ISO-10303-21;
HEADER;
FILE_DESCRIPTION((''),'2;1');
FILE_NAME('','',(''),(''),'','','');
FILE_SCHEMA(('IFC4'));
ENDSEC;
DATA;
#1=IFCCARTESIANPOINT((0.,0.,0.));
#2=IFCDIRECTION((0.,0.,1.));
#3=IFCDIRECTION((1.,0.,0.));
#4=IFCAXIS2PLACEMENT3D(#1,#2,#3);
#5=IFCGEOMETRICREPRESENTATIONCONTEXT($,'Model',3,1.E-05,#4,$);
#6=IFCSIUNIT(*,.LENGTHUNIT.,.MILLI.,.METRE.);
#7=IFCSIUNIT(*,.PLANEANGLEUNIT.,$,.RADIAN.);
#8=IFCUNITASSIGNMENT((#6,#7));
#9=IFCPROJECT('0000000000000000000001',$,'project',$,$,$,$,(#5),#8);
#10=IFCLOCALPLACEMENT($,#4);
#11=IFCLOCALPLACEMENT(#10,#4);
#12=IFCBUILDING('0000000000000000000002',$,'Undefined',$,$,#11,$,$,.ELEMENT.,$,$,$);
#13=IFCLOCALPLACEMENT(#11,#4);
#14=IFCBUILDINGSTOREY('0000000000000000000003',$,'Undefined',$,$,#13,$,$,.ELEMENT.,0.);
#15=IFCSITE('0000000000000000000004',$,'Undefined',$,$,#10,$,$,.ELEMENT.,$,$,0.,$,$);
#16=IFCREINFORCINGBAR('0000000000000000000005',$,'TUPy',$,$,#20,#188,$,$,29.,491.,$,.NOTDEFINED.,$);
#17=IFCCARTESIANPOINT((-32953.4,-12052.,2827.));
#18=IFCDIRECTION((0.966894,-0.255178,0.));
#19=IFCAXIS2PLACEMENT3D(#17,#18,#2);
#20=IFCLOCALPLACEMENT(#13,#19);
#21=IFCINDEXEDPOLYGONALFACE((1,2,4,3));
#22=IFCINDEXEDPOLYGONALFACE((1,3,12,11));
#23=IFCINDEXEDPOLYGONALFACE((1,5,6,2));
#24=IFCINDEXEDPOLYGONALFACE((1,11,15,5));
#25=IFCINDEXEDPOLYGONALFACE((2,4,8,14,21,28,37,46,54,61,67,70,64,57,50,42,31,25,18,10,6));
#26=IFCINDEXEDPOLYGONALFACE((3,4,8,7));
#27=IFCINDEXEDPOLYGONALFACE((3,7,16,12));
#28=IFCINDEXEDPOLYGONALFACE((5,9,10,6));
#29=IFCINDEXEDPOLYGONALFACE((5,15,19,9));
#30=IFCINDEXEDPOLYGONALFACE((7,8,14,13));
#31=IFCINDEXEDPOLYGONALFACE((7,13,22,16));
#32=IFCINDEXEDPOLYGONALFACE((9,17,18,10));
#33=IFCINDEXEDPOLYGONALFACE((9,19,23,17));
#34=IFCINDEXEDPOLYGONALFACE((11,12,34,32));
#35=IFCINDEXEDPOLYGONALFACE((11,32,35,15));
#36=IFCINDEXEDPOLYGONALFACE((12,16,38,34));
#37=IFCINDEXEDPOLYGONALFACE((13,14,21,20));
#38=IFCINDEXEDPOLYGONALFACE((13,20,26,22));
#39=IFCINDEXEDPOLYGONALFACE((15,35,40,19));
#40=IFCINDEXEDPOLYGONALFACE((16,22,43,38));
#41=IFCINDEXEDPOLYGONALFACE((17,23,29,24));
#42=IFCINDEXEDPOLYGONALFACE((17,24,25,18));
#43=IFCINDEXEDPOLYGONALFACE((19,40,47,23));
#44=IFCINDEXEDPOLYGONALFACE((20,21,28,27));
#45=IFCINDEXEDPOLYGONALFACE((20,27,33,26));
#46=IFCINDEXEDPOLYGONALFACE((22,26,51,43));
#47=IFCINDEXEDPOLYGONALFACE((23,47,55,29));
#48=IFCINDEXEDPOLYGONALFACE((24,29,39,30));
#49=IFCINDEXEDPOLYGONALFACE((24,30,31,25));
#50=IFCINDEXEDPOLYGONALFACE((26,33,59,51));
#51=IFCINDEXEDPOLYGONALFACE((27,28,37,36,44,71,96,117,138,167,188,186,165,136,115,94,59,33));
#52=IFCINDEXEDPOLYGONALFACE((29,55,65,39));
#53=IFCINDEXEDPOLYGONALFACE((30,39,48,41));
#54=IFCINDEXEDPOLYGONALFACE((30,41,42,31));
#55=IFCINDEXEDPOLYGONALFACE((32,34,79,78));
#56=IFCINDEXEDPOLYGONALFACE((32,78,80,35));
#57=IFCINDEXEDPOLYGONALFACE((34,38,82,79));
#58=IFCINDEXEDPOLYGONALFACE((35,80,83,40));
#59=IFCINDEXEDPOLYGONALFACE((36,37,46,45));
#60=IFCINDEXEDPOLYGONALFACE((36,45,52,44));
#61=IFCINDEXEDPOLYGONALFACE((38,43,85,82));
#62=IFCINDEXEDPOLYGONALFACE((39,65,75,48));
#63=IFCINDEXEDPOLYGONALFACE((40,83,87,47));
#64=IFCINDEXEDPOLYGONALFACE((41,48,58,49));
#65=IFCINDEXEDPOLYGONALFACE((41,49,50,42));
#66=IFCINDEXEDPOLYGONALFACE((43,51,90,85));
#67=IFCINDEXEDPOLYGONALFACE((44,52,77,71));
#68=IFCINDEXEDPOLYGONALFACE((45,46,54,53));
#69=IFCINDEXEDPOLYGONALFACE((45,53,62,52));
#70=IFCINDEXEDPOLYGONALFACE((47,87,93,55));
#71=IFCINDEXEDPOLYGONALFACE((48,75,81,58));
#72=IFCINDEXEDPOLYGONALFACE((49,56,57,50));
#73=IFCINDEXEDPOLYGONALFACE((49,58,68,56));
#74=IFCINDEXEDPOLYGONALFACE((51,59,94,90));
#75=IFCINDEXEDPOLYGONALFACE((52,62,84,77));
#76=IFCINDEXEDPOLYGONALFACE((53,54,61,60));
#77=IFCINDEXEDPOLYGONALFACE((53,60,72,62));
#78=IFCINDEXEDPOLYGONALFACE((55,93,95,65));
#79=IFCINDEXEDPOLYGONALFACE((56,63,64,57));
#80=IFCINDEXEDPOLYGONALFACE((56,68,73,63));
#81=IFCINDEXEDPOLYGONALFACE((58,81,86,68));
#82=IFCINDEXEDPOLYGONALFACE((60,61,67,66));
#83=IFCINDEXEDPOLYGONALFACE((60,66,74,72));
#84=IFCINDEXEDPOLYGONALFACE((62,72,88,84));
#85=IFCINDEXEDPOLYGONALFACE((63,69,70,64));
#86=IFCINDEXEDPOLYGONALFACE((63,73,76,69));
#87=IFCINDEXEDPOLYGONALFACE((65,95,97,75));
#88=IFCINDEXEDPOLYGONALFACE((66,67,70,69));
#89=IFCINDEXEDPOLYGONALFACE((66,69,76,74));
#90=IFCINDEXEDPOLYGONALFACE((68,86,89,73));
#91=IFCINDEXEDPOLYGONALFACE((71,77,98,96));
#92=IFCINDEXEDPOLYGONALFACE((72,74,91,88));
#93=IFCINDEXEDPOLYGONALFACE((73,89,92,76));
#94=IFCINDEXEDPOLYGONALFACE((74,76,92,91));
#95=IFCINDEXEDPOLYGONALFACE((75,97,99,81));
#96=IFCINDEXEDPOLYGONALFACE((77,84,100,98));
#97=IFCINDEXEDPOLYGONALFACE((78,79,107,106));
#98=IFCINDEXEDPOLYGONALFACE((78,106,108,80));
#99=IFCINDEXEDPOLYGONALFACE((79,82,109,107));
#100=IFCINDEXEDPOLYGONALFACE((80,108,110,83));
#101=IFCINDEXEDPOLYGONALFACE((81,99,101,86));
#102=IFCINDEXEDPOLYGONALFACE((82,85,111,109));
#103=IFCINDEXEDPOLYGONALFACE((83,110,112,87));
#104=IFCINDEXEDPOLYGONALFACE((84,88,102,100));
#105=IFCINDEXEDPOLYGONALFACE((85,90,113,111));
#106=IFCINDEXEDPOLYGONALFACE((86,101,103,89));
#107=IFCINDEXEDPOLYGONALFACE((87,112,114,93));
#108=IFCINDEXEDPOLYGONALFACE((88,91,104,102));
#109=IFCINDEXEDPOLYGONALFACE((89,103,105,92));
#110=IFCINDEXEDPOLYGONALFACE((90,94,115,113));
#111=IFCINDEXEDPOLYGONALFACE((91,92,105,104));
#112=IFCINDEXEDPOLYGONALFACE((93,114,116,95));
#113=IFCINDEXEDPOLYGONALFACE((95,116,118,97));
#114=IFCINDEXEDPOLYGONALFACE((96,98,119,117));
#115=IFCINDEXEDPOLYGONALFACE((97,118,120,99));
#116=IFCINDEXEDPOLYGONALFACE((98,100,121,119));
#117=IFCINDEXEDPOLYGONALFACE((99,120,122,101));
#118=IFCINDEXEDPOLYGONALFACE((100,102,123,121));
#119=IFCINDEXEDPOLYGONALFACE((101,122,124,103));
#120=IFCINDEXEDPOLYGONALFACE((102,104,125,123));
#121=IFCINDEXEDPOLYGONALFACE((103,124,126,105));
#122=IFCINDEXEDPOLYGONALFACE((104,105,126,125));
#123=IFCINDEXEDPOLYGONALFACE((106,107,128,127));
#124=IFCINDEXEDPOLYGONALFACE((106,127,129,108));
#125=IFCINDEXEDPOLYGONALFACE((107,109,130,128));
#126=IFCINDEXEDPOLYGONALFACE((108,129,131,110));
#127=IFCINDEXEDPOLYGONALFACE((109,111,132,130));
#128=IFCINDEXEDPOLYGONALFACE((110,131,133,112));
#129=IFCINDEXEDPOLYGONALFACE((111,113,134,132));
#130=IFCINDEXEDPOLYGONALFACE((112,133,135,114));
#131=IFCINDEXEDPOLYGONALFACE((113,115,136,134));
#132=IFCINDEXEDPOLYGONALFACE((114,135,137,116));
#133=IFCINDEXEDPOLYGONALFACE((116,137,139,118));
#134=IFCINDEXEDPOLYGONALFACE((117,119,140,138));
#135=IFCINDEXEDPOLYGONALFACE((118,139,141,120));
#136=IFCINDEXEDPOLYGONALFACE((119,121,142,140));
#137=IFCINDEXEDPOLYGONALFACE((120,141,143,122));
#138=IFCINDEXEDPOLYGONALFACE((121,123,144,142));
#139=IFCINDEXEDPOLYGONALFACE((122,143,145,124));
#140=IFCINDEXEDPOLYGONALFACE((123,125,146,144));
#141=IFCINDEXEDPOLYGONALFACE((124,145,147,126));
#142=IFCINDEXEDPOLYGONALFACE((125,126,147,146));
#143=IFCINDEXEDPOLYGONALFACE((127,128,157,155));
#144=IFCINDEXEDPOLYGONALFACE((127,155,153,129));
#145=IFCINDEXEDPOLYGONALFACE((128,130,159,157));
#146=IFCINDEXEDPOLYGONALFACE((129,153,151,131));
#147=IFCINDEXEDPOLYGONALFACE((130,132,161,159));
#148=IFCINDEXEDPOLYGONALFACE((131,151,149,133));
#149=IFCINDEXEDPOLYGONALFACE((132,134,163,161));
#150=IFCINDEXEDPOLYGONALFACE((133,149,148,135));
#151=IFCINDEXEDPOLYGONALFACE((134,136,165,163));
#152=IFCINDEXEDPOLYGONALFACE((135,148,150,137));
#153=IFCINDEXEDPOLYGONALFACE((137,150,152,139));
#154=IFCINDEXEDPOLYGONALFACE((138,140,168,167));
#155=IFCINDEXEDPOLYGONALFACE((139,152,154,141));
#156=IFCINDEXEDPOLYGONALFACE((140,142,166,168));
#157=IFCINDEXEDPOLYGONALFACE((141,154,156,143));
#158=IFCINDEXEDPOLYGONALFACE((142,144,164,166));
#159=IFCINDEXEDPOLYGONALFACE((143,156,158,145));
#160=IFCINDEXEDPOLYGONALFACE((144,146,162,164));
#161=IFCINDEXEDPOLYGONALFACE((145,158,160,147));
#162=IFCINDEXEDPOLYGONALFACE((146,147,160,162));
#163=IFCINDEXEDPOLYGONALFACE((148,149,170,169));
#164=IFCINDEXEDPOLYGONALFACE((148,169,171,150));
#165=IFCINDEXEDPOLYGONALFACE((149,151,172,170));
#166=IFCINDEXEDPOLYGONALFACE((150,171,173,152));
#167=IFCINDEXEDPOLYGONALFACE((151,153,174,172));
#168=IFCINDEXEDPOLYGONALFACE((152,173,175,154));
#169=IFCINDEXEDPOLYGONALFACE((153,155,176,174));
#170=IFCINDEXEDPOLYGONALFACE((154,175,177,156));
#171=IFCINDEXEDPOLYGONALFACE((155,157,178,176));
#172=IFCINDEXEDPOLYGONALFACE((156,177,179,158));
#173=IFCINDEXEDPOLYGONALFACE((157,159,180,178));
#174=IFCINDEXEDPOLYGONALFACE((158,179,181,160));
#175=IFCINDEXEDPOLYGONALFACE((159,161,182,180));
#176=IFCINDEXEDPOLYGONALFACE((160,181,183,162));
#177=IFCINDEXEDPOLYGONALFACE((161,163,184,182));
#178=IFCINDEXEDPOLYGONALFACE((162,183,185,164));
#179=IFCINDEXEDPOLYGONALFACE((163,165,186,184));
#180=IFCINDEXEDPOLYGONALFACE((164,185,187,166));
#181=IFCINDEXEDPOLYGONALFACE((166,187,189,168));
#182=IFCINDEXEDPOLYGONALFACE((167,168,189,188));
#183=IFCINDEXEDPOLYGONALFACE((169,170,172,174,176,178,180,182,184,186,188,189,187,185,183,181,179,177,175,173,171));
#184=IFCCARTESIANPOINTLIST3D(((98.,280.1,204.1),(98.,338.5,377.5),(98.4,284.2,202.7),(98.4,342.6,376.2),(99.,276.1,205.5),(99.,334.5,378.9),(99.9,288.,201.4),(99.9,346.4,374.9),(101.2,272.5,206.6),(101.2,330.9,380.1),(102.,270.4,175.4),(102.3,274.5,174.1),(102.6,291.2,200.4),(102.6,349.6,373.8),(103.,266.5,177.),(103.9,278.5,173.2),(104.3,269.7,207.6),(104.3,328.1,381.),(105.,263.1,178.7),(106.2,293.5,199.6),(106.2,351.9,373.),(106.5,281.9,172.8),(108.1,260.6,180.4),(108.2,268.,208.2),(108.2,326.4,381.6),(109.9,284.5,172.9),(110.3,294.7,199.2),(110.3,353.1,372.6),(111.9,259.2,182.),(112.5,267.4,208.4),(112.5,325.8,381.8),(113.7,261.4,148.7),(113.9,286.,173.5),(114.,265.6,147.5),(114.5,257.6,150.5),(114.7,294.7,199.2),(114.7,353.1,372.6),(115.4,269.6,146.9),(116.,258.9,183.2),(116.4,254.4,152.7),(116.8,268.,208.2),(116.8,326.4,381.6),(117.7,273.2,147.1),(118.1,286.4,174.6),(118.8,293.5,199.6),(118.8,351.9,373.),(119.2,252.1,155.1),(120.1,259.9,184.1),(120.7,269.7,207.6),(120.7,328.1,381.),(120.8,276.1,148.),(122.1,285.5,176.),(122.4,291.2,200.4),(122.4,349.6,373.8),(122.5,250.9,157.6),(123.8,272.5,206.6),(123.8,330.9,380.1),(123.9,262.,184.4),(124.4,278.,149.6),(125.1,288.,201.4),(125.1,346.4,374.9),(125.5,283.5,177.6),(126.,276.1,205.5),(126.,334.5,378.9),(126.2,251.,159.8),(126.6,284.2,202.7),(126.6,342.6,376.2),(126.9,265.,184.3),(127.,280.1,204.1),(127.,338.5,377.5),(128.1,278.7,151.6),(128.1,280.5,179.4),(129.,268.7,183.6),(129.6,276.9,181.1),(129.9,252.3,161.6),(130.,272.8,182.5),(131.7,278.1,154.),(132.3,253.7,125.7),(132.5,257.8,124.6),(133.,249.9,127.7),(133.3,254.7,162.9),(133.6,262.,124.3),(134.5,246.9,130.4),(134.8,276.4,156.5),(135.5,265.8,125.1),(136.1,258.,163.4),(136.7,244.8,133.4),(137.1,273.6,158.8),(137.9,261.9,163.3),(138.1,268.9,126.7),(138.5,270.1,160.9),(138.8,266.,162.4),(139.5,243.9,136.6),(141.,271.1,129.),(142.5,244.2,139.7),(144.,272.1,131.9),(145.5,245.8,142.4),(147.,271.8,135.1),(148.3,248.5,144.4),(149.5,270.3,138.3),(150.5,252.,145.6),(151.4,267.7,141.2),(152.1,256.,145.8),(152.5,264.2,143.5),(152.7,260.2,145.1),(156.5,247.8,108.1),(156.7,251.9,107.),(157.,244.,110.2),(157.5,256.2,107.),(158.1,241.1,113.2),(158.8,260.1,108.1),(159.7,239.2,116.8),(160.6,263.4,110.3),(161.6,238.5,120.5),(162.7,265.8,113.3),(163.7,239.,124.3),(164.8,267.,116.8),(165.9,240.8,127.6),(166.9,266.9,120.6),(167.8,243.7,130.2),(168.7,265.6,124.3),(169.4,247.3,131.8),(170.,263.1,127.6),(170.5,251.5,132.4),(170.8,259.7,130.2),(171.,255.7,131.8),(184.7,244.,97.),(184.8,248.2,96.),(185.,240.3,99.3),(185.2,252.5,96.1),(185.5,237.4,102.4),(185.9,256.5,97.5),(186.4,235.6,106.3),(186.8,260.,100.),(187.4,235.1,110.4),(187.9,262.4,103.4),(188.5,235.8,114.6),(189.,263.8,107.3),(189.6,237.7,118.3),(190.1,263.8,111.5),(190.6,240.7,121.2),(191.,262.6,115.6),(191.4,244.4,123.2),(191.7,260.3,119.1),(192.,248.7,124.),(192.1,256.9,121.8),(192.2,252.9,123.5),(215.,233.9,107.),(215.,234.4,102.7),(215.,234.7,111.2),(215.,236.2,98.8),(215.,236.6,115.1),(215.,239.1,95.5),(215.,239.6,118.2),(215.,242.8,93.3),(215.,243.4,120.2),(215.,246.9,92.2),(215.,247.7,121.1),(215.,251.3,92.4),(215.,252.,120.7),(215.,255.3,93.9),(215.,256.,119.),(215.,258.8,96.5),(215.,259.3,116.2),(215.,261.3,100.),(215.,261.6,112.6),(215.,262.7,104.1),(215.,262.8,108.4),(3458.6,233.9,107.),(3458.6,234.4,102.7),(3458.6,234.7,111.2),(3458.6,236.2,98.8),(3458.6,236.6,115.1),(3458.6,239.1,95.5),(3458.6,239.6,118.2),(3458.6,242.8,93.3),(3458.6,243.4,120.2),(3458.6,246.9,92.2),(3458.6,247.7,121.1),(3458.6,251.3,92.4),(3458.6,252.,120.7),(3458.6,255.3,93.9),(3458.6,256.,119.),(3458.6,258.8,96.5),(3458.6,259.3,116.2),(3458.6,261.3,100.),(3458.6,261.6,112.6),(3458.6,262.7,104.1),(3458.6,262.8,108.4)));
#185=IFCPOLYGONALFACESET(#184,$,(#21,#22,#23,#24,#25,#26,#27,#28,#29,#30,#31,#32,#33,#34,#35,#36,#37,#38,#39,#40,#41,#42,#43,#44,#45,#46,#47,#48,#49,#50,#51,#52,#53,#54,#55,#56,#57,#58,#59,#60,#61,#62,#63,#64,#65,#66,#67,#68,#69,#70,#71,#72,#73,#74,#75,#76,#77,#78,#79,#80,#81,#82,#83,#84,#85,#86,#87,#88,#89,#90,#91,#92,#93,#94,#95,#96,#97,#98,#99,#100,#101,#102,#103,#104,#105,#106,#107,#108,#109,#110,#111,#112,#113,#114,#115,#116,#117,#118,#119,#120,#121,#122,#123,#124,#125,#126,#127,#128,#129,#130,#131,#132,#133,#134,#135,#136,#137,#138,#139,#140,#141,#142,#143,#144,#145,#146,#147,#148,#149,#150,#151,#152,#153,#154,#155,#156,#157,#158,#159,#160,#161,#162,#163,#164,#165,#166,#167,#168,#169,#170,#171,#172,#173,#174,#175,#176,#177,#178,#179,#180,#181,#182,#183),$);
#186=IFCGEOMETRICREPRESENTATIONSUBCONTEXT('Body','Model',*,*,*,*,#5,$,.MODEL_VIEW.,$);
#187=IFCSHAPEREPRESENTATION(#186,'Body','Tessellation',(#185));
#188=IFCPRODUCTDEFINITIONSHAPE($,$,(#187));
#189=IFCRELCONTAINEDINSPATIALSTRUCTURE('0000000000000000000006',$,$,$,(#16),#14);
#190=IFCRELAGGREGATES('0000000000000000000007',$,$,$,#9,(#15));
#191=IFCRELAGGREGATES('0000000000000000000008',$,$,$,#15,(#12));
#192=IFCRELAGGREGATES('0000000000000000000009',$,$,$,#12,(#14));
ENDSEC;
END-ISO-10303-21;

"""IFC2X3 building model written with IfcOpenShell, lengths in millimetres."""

from ifc_helpers import new_model, entity, si_unit, frame, origin_with_axes, place, context, subcontext, project, spatial, source, transform, mapped, element, save


model = new_model("IFC2X3")

# Units and contexts
model_context = context("Model", 3, precision=1e-05, world=origin_with_axes())
body_context = subcontext(model_context, "Body", "Model", "MODEL_VIEW")
ifc_project = project(units=[si_unit("LENGTHUNIT", "METRE", prefix="MILLI"), si_unit("PLANEANGLEUNIT", "RADIAN")], contexts=[model_context])

# Site, building, storey
site_placement = place(None, origin_with_axes())
site = spatial("IfcSite", under=ifc_project, at=site_placement, Name="Undefined", CompositionType="ELEMENT", RefElevation=0.0)
building_placement = place(site_placement, origin_with_axes())
building = spatial("IfcBuilding", under=site, at=building_placement, Name="Undefined", CompositionType="ELEMENT")
storey_placement = place(building_placement, origin_with_axes())
storey = spatial("IfcBuildingStorey", under=building, at=storey_placement, Name="Undefined", CompositionType="ELEMENT", Elevation=0.0)

# Reinforcing bar
shared_shape_1 = source(origin_with_axes(), body_context, "Body", "AdvancedSweptSolid", [
    entity("IfcSweptDiskSolid", entity("IfcCompositeCurve", [entity("IfcCompositeCurveSegment", "CONTINUOUS", True, entity("IfcTrimmedCurve", entity("IfcLine", entity("IfcCartesianPoint", [0.0, 0.0, 0.0]), entity("IfcVector", entity("IfcDirection", [0.0, -0.319082, -0.947727]), 1.0)), [entity("IfcParameterValue", 0.0)], [entity("IfcParameterValue", 183.0)], True, "PARAMETER")), entity("IfcCompositeCurveSegment", "CONTINUOUS", True, entity("IfcTrimmedCurve", entity("IfcCircle", entity("IfcAxis2Placement3D", entity("IfcCartesianPoint", [102.5, -58.4, -173.4]), entity("IfcDirection", [0.0, -0.947727, 0.319082]), entity("IfcDirection", [-1.0, 0.0, 0.0])), 102.5), [entity("IfcParameterValue", 0.0)], [entity("IfcParameterValue", 1.570796)], True, "PARAMETER")), entity("IfcCompositeCurveSegment", "DISCONTINUOUS", True, entity("IfcTrimmedCurve", entity("IfcLine", entity("IfcCartesianPoint", [102.5, -91.1, -270.6]), entity("IfcVector", entity("IfcDirection", [1.0, 0.0, 0.0]), 1.0)), [entity("IfcParameterValue", 0.0)], [entity("IfcParameterValue", 3243.607639)], True, "PARAMETER"))], False), 14.5, None, 0.0, 3428.2),
])
reinforcing_bar_1_placement = place(storey_placement, frame((-32953.4, -12052.0, 2827.0), z_axis=(0.966894, -0.255178, 0.0), x_axis=(0.0, 0.0, 1.0)))
element("IfcReinforcingBar", 1, at=reinforcing_bar_1_placement, inside=storey, Name="TUPy", BarRole="NOTDEFINED", CrossSectionArea=491.0, NominalDiameter=29.0, context=body_context, shape_type="MappedRepresentation", body=[
    mapped(shared_shape_1, transform((112.5, 339.5, 377.2))),
])

save(model, "model.ifc")
